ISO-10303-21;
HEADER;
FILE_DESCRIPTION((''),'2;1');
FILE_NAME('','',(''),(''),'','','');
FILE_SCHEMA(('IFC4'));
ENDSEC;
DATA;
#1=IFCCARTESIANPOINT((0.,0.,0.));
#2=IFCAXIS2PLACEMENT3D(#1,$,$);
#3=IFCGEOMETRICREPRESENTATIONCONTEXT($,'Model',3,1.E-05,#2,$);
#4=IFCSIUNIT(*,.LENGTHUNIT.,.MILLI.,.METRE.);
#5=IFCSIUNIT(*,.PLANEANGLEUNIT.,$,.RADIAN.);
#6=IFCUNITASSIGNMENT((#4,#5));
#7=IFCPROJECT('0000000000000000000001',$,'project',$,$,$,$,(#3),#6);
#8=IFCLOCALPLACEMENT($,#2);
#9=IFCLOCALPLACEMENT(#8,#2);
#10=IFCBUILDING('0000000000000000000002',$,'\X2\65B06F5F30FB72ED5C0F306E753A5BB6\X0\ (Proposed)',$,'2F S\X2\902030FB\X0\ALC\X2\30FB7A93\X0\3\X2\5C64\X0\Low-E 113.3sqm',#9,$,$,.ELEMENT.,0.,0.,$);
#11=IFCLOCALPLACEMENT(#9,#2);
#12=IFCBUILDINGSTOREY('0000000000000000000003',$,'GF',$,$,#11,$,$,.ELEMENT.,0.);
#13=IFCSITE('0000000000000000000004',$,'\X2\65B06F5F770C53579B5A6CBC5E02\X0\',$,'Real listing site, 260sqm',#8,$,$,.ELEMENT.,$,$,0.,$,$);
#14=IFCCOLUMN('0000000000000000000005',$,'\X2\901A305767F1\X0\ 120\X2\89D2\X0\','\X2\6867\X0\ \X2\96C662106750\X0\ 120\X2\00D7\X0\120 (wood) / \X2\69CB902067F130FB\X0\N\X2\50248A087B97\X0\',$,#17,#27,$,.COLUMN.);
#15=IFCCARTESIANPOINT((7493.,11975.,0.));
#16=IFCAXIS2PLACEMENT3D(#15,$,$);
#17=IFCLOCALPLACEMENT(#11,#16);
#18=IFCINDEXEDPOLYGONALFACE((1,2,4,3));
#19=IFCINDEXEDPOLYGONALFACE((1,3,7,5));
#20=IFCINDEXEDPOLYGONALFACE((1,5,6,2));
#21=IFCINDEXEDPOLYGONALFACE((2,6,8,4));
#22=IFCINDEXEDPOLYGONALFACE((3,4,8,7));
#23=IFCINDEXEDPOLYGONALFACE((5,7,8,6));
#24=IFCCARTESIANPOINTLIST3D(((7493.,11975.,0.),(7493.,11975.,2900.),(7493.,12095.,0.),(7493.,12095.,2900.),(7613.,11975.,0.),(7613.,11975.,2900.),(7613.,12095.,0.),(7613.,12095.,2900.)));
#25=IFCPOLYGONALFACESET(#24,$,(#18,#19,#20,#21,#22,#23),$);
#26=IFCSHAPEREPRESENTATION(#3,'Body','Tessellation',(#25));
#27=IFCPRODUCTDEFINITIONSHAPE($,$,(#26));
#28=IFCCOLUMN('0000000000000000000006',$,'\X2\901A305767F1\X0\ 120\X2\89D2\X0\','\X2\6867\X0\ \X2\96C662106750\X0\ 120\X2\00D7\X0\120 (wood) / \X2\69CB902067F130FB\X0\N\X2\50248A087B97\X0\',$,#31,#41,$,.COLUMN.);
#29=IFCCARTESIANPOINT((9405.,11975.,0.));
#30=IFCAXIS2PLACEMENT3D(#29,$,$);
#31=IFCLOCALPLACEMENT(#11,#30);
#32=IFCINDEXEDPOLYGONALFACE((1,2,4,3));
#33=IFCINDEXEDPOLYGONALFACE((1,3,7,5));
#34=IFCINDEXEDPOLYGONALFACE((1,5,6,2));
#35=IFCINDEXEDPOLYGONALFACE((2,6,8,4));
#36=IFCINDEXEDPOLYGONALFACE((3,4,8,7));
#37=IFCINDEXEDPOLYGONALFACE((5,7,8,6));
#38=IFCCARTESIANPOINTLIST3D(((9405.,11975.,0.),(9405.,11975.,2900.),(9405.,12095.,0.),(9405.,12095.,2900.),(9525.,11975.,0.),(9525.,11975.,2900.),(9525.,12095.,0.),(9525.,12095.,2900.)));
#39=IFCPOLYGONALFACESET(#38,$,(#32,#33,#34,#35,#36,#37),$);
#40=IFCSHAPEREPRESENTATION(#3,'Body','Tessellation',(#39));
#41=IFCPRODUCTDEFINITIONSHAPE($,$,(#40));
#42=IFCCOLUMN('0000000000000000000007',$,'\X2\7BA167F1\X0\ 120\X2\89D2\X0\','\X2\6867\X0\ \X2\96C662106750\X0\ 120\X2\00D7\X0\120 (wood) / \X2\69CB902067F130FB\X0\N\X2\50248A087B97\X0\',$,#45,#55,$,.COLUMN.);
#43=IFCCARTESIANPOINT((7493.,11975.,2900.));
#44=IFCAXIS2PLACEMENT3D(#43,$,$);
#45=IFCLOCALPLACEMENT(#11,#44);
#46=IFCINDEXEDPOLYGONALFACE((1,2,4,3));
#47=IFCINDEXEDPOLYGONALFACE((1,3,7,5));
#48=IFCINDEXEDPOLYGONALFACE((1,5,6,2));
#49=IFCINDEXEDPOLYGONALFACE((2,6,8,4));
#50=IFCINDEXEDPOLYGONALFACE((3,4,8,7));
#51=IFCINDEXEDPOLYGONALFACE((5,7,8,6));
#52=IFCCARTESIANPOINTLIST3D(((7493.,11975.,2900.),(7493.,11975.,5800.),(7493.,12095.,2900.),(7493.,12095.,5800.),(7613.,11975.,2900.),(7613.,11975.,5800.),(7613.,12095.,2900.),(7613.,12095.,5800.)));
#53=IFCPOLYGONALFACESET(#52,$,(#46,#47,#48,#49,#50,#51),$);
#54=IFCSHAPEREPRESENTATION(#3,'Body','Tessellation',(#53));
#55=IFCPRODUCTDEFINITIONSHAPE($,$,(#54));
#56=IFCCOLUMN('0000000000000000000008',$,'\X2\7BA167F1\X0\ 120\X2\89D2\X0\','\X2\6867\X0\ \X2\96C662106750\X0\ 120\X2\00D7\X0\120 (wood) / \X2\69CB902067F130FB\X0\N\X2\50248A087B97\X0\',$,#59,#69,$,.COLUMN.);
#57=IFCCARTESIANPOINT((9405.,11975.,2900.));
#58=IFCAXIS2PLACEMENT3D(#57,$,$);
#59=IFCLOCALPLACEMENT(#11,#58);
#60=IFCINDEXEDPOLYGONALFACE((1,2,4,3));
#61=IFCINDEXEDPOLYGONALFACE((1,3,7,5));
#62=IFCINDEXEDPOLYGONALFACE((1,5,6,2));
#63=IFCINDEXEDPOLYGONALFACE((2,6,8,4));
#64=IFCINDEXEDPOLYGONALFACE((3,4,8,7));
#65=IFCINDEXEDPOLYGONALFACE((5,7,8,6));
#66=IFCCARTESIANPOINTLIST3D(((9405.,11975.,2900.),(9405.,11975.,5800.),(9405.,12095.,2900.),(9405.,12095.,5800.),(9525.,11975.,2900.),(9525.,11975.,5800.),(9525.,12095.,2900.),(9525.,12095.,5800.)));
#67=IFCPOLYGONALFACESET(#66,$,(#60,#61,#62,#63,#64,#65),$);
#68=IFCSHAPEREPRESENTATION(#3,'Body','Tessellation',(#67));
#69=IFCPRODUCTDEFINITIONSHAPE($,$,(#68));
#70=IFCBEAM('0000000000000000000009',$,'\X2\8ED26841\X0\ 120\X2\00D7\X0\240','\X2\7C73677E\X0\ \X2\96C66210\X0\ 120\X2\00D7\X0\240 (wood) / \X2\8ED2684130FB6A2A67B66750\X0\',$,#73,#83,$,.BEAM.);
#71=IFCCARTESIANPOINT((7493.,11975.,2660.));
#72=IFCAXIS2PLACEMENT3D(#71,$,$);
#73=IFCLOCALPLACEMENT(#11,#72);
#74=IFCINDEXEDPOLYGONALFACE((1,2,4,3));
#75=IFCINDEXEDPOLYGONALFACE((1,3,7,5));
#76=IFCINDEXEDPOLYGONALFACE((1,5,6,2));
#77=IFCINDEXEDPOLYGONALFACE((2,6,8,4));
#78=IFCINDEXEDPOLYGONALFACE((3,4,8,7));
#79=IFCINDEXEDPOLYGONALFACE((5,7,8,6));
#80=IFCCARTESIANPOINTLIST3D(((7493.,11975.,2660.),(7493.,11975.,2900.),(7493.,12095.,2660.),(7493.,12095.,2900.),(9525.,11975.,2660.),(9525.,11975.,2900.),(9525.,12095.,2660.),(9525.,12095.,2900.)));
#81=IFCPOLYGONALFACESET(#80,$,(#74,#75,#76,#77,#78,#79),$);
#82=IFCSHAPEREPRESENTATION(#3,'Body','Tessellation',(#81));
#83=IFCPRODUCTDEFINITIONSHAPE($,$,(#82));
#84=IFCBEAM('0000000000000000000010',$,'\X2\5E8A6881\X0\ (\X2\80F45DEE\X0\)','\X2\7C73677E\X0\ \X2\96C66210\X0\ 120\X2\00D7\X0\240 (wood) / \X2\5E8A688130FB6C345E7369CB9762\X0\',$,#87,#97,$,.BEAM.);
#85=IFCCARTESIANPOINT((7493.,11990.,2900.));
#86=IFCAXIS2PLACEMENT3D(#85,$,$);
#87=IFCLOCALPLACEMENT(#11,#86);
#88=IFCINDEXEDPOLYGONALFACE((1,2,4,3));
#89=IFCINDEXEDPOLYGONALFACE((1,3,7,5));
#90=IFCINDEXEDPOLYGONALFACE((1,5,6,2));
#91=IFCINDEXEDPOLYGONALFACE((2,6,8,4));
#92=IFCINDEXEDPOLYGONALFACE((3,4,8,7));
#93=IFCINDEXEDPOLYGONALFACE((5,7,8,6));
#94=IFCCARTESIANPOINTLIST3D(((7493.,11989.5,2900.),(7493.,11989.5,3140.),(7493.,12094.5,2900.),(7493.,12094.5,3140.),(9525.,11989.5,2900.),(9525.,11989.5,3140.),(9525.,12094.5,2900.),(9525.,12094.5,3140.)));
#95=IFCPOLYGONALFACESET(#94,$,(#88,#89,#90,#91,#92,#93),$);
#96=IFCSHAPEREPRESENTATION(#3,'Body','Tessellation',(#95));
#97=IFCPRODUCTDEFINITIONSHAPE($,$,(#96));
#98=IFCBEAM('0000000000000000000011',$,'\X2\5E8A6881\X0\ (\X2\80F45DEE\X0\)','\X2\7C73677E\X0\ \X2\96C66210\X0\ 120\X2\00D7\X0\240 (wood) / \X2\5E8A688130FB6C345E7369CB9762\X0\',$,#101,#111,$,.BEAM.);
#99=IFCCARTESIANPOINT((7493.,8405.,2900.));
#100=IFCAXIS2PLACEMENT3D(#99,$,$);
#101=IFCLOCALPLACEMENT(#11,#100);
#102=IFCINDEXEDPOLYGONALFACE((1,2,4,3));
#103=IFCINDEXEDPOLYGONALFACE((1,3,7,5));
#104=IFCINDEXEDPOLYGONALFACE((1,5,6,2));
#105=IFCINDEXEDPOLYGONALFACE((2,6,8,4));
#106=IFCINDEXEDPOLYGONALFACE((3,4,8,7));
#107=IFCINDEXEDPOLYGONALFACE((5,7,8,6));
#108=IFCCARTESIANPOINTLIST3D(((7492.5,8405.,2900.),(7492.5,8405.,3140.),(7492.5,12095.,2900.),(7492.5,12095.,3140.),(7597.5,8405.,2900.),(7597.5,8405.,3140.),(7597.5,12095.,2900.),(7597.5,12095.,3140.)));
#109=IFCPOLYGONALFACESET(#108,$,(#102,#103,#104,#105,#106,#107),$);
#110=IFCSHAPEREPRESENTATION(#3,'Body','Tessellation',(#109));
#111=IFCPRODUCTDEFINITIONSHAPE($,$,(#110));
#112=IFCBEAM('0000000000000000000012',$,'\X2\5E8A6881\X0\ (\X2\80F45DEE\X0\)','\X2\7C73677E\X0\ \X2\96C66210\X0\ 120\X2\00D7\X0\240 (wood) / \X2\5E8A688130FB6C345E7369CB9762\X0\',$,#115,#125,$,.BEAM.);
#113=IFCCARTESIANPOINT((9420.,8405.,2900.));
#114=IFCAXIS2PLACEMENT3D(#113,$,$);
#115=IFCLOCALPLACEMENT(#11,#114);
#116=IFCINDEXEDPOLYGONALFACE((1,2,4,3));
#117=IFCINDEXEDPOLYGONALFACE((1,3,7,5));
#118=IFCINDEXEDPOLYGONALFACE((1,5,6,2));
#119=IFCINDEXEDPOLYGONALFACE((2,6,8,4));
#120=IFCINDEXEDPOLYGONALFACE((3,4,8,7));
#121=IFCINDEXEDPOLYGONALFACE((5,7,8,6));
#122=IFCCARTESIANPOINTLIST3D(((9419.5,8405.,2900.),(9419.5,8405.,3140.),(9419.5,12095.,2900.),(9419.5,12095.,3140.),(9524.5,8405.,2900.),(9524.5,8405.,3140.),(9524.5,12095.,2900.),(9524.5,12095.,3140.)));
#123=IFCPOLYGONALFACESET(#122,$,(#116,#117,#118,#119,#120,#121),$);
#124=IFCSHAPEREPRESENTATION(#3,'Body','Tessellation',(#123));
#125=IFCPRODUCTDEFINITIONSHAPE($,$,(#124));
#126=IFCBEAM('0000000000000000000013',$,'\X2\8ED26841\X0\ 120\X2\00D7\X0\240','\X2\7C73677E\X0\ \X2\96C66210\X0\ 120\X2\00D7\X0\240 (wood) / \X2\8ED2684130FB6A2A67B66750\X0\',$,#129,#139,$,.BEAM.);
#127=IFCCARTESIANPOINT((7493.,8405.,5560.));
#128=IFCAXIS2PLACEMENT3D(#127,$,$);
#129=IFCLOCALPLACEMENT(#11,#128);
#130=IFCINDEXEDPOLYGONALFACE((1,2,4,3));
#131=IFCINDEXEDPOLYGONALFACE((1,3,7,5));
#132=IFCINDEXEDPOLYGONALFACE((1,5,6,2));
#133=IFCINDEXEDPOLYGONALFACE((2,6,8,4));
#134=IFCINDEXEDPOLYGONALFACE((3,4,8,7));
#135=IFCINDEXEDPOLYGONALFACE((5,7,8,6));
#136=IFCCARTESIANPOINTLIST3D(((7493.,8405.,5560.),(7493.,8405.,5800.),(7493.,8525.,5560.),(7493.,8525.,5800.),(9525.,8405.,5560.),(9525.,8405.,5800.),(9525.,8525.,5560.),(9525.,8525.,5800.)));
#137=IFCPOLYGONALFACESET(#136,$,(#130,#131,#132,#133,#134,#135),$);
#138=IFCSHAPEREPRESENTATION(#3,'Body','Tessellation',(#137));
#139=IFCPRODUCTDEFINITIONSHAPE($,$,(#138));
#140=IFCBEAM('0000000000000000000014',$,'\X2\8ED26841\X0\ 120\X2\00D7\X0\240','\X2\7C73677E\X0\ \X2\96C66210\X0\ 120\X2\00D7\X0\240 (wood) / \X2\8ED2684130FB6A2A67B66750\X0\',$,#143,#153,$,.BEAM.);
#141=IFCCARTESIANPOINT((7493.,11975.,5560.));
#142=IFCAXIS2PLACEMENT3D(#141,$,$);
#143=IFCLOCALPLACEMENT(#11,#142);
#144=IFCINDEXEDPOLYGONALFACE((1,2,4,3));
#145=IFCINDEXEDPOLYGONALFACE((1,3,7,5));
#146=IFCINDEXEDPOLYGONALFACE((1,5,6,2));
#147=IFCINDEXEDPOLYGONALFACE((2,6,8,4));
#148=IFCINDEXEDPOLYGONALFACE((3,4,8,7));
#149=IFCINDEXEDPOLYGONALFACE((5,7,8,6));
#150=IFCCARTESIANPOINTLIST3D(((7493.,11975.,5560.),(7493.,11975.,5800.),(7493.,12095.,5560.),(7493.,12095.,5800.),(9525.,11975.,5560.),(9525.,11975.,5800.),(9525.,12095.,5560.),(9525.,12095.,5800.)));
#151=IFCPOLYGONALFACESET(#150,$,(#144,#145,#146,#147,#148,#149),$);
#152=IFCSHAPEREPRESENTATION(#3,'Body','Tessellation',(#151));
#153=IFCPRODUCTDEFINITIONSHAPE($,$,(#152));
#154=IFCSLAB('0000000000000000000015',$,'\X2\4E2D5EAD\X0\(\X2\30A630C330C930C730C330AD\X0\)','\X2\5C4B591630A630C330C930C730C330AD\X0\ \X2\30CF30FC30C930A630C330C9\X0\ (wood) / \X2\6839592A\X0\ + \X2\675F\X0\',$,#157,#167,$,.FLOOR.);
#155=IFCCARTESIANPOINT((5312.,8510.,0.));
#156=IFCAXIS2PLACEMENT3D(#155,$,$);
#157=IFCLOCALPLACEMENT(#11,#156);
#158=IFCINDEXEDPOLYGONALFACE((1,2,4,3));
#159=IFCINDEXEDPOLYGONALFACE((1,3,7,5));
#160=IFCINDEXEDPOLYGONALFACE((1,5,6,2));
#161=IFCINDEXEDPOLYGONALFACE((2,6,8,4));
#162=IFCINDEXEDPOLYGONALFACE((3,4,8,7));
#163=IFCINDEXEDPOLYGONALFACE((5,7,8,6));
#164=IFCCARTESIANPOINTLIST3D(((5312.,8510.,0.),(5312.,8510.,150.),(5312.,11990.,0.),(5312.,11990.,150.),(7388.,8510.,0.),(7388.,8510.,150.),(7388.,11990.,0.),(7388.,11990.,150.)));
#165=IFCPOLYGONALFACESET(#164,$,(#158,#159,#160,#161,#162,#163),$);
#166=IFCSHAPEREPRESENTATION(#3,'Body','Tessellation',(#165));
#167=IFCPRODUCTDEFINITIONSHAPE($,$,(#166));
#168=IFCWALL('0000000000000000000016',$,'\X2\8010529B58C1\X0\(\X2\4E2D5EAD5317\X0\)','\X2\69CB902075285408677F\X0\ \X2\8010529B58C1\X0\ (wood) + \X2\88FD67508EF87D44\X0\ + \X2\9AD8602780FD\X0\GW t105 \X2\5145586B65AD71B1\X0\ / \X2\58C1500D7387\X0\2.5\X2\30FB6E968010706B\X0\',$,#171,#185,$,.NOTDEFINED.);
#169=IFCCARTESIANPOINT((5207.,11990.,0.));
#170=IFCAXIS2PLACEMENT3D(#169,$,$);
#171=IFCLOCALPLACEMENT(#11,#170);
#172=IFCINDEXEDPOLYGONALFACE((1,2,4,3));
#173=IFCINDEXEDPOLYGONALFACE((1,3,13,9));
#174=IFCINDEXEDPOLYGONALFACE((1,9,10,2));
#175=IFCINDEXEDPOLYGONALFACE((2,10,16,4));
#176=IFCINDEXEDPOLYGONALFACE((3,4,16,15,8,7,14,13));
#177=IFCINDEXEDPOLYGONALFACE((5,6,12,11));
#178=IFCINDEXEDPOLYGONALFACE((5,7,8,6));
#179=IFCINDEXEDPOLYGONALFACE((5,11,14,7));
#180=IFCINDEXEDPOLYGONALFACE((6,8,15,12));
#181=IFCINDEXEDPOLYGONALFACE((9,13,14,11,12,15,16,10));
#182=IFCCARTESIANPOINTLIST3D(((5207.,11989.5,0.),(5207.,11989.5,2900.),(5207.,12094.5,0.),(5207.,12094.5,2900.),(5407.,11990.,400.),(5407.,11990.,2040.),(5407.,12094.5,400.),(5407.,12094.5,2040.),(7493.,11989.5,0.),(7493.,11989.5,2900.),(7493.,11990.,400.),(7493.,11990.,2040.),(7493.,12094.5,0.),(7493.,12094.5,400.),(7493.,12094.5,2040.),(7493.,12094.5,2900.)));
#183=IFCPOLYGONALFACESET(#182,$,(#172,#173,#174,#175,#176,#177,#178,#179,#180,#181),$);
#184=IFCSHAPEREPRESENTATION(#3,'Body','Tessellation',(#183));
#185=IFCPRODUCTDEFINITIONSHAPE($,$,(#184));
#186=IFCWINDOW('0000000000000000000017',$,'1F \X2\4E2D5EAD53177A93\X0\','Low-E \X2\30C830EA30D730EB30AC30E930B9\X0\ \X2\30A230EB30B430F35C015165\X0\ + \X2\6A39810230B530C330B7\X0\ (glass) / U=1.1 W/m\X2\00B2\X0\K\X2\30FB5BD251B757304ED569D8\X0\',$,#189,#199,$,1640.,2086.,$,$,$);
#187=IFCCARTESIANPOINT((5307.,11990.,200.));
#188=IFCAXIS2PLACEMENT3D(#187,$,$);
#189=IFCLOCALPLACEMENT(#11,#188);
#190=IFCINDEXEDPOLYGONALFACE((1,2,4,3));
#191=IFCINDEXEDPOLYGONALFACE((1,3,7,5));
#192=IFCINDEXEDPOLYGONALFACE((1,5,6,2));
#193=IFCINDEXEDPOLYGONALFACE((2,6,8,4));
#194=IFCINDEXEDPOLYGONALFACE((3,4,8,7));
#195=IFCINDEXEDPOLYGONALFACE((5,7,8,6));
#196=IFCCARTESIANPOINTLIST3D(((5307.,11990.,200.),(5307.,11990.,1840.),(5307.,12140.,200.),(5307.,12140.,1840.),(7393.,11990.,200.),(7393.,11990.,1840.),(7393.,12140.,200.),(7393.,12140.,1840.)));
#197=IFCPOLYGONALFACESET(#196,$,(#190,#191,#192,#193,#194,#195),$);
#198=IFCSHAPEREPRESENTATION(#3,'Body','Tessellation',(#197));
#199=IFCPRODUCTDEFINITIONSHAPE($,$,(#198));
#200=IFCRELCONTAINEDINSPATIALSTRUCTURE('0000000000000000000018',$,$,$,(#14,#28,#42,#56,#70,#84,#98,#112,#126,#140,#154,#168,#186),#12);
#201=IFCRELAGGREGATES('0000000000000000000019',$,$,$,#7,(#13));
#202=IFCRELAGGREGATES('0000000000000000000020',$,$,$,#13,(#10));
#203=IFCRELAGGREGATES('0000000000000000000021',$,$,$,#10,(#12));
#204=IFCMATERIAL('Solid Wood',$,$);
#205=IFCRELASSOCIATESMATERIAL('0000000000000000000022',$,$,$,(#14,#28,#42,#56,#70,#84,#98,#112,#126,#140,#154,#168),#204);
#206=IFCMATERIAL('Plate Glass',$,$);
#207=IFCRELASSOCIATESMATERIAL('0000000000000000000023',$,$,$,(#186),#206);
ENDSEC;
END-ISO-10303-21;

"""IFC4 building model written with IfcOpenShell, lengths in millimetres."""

from ifc_helpers import new_model, si_unit, frame, frame_2d, origin, place, context, project, spatial, rectangle, extrude, material, element, fill, save


model = new_model("IFC4")

# Units and contexts
model_context = context("Model", 3, precision=1e-05, world=origin())
ifc_project = project(units=[si_unit("LENGTHUNIT", "METRE", prefix="MILLI"), si_unit("PLANEANGLEUNIT", "RADIAN")], contexts=[model_context])

# Site, building, storey
site_placement = place(None, origin())
site = spatial("IfcSite", under=ifc_project, at=site_placement, Name="新潟県南魚沼市", ObjectType="Real listing site, 260sqm", CompositionType="ELEMENT", RefElevation=0.0)
building_placement = place(site_placement, origin())
building = spatial("IfcBuilding", under=site, at=building_placement, Name="新潟・狭小の町家 (Proposed)", ObjectType="2F S造・ALC・窓3層Low-E 113.3sqm", CompositionType="ELEMENT", ElevationOfRefHeight=0.0, ElevationOfTerrain=0.0)
storey_placement = place(building_placement, origin())
storey = spatial("IfcBuildingStorey", under=building, at=storey_placement, Name="GF", CompositionType="ELEMENT", Elevation=0.0)

# Columns
ifc_material_1 = material(Name="Solid Wood")
column_1_placement = place(storey_placement, frame((7493.0, 11975.0, 0.0)))
element("IfcColumn", 1, at=column_1_placement, inside=storey, material=ifc_material_1, Name="通し柱 120角", Description="桧 集成材 120×120 (wood) / 構造柱・N値計算", PredefinedType="COLUMN", context=model_context, shape_type="SweptSolid", body=[
    extrude(rectangle(XDim=120.0, YDim=120.0, at=frame_2d((60.0, 60.0))), frame((7493.0, 11975.0, 0.0)), (0.0, 0.0, 1.0), 2900.0),
])
column_2_placement = place(storey_placement, frame((9405.0, 11975.0, 0.0)))
element("IfcColumn", 2, at=column_2_placement, inside=storey, material=ifc_material_1, Name="通し柱 120角", Description="桧 集成材 120×120 (wood) / 構造柱・N値計算", PredefinedType="COLUMN", context=model_context, shape_type="SweptSolid", body=[
    extrude(rectangle(XDim=120.0, YDim=120.0, at=frame_2d((60.0, 60.0))), frame((9405.0, 11975.0, 0.0)), (0.0, 0.0, 1.0), 2900.0),
])
column_3_placement = place(storey_placement, frame((7493.0, 11975.0, 2900.0)))
element("IfcColumn", 3, at=column_3_placement, inside=storey, material=ifc_material_1, Name="管柱 120角", Description="桧 集成材 120×120 (wood) / 構造柱・N値計算", PredefinedType="COLUMN", context=model_context, shape_type="SweptSolid", body=[
    extrude(rectangle(XDim=120.0, YDim=120.0, at=frame_2d((60.0, 60.0))), frame((7493.0, 11975.0, 2900.0)), (0.0, 0.0, 1.0), 2900.0),
])
column_4_placement = place(storey_placement, frame((9405.0, 11975.0, 2900.0)))
element("IfcColumn", 4, at=column_4_placement, inside=storey, material=ifc_material_1, Name="管柱 120角", Description="桧 集成材 120×120 (wood) / 構造柱・N値計算", PredefinedType="COLUMN", context=model_context, shape_type="SweptSolid", body=[
    extrude(rectangle(XDim=120.0, YDim=120.0, at=frame_2d((60.0, 60.0))), frame((9405.0, 11975.0, 2900.0)), (0.0, 0.0, 1.0), 2900.0),
])

# Beams
beam_1_placement = place(storey_placement, frame((7493.0, 11975.0, 2660.0)))
element("IfcBeam", 5, at=beam_1_placement, inside=storey, material=ifc_material_1, Name="軒桁 120×240", Description="米松 集成 120×240 (wood) / 軒桁・横架材", PredefinedType="BEAM", context=model_context, shape_type="SweptSolid", body=[
    extrude(rectangle(XDim=2032.0, YDim=120.0, at=frame_2d((1016.0, 60.0))), frame((7493.0, 11975.0, 2660.0)), (0.0, 0.0, 1.0), 240.0),
])
beam_2_placement = place(storey_placement, frame((7493.0, 11990.0, 2900.0)))
element("IfcBeam", 6, at=beam_2_placement, inside=storey, material=ifc_material_1, Name="床梁 (胴差)", Description="米松 集成 120×240 (wood) / 床梁・水平構面", PredefinedType="BEAM", context=model_context, shape_type="SweptSolid", body=[
    extrude(rectangle(XDim=2032.0, YDim=105.0, at=frame_2d((1016.0, 52.0))), frame((7493.0, 11990.0, 2900.0)), (0.0, 0.0, 1.0), 240.0),
])
beam_3_placement = place(storey_placement, frame((7493.0, 8405.0, 2900.0)))
element("IfcBeam", 7, at=beam_3_placement, inside=storey, material=ifc_material_1, Name="床梁 (胴差)", Description="米松 集成 120×240 (wood) / 床梁・水平構面", PredefinedType="BEAM", context=model_context, shape_type="SweptSolid", body=[
    extrude(rectangle(XDim=105.0, YDim=3690.0, at=frame_2d((52.0, 1845.0))), frame((7493.0, 8405.0, 2900.0)), (0.0, 0.0, 1.0), 240.0),
])
beam_4_placement = place(storey_placement, frame((9420.0, 8405.0, 2900.0)))
element("IfcBeam", 8, at=beam_4_placement, inside=storey, material=ifc_material_1, Name="床梁 (胴差)", Description="米松 集成 120×240 (wood) / 床梁・水平構面", PredefinedType="BEAM", context=model_context, shape_type="SweptSolid", body=[
    extrude(rectangle(XDim=105.0, YDim=3690.0, at=frame_2d((52.0, 1845.0))), frame((9420.0, 8405.0, 2900.0)), (0.0, 0.0, 1.0), 240.0),
])
beam_5_placement = place(storey_placement, frame((7493.0, 8405.0, 5560.0)))
element("IfcBeam", 9, at=beam_5_placement, inside=storey, material=ifc_material_1, Name="軒桁 120×240", Description="米松 集成 120×240 (wood) / 軒桁・横架材", PredefinedType="BEAM", context=model_context, shape_type="SweptSolid", body=[
    extrude(rectangle(XDim=2032.0, YDim=120.0, at=frame_2d((1016.0, 60.0))), frame((7493.0, 8405.0, 5560.0)), (0.0, 0.0, 1.0), 240.0),
])
beam_6_placement = place(storey_placement, frame((7493.0, 11975.0, 5560.0)))
element("IfcBeam", 10, at=beam_6_placement, inside=storey, material=ifc_material_1, Name="軒桁 120×240", Description="米松 集成 120×240 (wood) / 軒桁・横架材", PredefinedType="BEAM", context=model_context, shape_type="SweptSolid", body=[
    extrude(rectangle(XDim=2032.0, YDim=120.0, at=frame_2d((1016.0, 60.0))), frame((7493.0, 11975.0, 5560.0)), (0.0, 0.0, 1.0), 240.0),
])

# Slab
slab_placement = place(storey_placement, frame((5312.0, 8510.0, 0.0)))
element("IfcSlab", 11, at=slab_placement, inside=storey, material=ifc_material_1, Name="中庭(ウッドデッキ)", Description="屋外ウッドデッキ ハードウッド (wood) / 根太 + 束", PredefinedType="FLOOR", context=model_context, shape_type="SweptSolid", body=[
    extrude(rectangle(XDim=2076.0, YDim=3480.0, at=frame_2d((1038.0, 1740.0))), frame((5312.0, 8510.0, 0.0)), (0.0, 0.0, 1.0), 150.0),
])

# Wall, opening, window
wall_1_placement = place(storey_placement, frame((5207.0, 11990.0, 0.0)))
wall_1 = element("IfcWall", 12, at=wall_1_placement, inside=storey, material=ifc_material_1, Name="耐力壁(中庭北)", Description="構造用合板 耐力壁 (wood) + 製材軸組 + 高性能GW t105 充填断熱 / 壁倍率2.5・準耐火", PredefinedType="NOTDEFINED", context=model_context, shape_type="SweptSolid", body=[
    extrude(rectangle(XDim=2286.0, YDim=105.0, at=frame_2d((1143.0, 52.0))), frame((5207.0, 11990.0, 0.0)), (0.0, 0.0, 1.0), 2900.0),
])
opening_1_placement = place(storey_placement, frame((5307.0, 11990.0, 200.0)))
opening_1 = element("IfcOpeningElement", 13, at=opening_1_placement, cuts=wall_1, PredefinedType="NOTDEFINED", context=model_context, shape_type="SweptSolid", body=[
    extrude(rectangle(XDim=2086.0, YDim=150.0, at=frame_2d((1043.0, 75.0))), frame((5307.0, 11990.0, 200.0)), (0.0, 0.0, 1.0), 1640.0),
])
ifc_material_2 = material(Name="Plate Glass")
window_1_placement = place(storey_placement, frame((5307.0, 11990.0, 200.0)))
window_1 = element("IfcWindow", 14, at=window_1_placement, inside=storey, material=ifc_material_2, Name="1F 中庭北窓", Description="Low-E トリプルガラス アルゴン封入 + 樹脂サッシ (glass) / U=1.1 W/m²K・寒冷地仕様", OverallHeight=1640.0, OverallWidth=2086.0, context=model_context, shape_type="SweptSolid", body=[
    extrude(rectangle(XDim=2086.0, YDim=150.0, at=frame_2d((1043.0, 75.0))), frame((5307.0, 11990.0, 200.0)), (0.0, 0.0, 1.0), 1640.0),
])
fill(opening_1, window_1)

save(model, "model.ifc")
